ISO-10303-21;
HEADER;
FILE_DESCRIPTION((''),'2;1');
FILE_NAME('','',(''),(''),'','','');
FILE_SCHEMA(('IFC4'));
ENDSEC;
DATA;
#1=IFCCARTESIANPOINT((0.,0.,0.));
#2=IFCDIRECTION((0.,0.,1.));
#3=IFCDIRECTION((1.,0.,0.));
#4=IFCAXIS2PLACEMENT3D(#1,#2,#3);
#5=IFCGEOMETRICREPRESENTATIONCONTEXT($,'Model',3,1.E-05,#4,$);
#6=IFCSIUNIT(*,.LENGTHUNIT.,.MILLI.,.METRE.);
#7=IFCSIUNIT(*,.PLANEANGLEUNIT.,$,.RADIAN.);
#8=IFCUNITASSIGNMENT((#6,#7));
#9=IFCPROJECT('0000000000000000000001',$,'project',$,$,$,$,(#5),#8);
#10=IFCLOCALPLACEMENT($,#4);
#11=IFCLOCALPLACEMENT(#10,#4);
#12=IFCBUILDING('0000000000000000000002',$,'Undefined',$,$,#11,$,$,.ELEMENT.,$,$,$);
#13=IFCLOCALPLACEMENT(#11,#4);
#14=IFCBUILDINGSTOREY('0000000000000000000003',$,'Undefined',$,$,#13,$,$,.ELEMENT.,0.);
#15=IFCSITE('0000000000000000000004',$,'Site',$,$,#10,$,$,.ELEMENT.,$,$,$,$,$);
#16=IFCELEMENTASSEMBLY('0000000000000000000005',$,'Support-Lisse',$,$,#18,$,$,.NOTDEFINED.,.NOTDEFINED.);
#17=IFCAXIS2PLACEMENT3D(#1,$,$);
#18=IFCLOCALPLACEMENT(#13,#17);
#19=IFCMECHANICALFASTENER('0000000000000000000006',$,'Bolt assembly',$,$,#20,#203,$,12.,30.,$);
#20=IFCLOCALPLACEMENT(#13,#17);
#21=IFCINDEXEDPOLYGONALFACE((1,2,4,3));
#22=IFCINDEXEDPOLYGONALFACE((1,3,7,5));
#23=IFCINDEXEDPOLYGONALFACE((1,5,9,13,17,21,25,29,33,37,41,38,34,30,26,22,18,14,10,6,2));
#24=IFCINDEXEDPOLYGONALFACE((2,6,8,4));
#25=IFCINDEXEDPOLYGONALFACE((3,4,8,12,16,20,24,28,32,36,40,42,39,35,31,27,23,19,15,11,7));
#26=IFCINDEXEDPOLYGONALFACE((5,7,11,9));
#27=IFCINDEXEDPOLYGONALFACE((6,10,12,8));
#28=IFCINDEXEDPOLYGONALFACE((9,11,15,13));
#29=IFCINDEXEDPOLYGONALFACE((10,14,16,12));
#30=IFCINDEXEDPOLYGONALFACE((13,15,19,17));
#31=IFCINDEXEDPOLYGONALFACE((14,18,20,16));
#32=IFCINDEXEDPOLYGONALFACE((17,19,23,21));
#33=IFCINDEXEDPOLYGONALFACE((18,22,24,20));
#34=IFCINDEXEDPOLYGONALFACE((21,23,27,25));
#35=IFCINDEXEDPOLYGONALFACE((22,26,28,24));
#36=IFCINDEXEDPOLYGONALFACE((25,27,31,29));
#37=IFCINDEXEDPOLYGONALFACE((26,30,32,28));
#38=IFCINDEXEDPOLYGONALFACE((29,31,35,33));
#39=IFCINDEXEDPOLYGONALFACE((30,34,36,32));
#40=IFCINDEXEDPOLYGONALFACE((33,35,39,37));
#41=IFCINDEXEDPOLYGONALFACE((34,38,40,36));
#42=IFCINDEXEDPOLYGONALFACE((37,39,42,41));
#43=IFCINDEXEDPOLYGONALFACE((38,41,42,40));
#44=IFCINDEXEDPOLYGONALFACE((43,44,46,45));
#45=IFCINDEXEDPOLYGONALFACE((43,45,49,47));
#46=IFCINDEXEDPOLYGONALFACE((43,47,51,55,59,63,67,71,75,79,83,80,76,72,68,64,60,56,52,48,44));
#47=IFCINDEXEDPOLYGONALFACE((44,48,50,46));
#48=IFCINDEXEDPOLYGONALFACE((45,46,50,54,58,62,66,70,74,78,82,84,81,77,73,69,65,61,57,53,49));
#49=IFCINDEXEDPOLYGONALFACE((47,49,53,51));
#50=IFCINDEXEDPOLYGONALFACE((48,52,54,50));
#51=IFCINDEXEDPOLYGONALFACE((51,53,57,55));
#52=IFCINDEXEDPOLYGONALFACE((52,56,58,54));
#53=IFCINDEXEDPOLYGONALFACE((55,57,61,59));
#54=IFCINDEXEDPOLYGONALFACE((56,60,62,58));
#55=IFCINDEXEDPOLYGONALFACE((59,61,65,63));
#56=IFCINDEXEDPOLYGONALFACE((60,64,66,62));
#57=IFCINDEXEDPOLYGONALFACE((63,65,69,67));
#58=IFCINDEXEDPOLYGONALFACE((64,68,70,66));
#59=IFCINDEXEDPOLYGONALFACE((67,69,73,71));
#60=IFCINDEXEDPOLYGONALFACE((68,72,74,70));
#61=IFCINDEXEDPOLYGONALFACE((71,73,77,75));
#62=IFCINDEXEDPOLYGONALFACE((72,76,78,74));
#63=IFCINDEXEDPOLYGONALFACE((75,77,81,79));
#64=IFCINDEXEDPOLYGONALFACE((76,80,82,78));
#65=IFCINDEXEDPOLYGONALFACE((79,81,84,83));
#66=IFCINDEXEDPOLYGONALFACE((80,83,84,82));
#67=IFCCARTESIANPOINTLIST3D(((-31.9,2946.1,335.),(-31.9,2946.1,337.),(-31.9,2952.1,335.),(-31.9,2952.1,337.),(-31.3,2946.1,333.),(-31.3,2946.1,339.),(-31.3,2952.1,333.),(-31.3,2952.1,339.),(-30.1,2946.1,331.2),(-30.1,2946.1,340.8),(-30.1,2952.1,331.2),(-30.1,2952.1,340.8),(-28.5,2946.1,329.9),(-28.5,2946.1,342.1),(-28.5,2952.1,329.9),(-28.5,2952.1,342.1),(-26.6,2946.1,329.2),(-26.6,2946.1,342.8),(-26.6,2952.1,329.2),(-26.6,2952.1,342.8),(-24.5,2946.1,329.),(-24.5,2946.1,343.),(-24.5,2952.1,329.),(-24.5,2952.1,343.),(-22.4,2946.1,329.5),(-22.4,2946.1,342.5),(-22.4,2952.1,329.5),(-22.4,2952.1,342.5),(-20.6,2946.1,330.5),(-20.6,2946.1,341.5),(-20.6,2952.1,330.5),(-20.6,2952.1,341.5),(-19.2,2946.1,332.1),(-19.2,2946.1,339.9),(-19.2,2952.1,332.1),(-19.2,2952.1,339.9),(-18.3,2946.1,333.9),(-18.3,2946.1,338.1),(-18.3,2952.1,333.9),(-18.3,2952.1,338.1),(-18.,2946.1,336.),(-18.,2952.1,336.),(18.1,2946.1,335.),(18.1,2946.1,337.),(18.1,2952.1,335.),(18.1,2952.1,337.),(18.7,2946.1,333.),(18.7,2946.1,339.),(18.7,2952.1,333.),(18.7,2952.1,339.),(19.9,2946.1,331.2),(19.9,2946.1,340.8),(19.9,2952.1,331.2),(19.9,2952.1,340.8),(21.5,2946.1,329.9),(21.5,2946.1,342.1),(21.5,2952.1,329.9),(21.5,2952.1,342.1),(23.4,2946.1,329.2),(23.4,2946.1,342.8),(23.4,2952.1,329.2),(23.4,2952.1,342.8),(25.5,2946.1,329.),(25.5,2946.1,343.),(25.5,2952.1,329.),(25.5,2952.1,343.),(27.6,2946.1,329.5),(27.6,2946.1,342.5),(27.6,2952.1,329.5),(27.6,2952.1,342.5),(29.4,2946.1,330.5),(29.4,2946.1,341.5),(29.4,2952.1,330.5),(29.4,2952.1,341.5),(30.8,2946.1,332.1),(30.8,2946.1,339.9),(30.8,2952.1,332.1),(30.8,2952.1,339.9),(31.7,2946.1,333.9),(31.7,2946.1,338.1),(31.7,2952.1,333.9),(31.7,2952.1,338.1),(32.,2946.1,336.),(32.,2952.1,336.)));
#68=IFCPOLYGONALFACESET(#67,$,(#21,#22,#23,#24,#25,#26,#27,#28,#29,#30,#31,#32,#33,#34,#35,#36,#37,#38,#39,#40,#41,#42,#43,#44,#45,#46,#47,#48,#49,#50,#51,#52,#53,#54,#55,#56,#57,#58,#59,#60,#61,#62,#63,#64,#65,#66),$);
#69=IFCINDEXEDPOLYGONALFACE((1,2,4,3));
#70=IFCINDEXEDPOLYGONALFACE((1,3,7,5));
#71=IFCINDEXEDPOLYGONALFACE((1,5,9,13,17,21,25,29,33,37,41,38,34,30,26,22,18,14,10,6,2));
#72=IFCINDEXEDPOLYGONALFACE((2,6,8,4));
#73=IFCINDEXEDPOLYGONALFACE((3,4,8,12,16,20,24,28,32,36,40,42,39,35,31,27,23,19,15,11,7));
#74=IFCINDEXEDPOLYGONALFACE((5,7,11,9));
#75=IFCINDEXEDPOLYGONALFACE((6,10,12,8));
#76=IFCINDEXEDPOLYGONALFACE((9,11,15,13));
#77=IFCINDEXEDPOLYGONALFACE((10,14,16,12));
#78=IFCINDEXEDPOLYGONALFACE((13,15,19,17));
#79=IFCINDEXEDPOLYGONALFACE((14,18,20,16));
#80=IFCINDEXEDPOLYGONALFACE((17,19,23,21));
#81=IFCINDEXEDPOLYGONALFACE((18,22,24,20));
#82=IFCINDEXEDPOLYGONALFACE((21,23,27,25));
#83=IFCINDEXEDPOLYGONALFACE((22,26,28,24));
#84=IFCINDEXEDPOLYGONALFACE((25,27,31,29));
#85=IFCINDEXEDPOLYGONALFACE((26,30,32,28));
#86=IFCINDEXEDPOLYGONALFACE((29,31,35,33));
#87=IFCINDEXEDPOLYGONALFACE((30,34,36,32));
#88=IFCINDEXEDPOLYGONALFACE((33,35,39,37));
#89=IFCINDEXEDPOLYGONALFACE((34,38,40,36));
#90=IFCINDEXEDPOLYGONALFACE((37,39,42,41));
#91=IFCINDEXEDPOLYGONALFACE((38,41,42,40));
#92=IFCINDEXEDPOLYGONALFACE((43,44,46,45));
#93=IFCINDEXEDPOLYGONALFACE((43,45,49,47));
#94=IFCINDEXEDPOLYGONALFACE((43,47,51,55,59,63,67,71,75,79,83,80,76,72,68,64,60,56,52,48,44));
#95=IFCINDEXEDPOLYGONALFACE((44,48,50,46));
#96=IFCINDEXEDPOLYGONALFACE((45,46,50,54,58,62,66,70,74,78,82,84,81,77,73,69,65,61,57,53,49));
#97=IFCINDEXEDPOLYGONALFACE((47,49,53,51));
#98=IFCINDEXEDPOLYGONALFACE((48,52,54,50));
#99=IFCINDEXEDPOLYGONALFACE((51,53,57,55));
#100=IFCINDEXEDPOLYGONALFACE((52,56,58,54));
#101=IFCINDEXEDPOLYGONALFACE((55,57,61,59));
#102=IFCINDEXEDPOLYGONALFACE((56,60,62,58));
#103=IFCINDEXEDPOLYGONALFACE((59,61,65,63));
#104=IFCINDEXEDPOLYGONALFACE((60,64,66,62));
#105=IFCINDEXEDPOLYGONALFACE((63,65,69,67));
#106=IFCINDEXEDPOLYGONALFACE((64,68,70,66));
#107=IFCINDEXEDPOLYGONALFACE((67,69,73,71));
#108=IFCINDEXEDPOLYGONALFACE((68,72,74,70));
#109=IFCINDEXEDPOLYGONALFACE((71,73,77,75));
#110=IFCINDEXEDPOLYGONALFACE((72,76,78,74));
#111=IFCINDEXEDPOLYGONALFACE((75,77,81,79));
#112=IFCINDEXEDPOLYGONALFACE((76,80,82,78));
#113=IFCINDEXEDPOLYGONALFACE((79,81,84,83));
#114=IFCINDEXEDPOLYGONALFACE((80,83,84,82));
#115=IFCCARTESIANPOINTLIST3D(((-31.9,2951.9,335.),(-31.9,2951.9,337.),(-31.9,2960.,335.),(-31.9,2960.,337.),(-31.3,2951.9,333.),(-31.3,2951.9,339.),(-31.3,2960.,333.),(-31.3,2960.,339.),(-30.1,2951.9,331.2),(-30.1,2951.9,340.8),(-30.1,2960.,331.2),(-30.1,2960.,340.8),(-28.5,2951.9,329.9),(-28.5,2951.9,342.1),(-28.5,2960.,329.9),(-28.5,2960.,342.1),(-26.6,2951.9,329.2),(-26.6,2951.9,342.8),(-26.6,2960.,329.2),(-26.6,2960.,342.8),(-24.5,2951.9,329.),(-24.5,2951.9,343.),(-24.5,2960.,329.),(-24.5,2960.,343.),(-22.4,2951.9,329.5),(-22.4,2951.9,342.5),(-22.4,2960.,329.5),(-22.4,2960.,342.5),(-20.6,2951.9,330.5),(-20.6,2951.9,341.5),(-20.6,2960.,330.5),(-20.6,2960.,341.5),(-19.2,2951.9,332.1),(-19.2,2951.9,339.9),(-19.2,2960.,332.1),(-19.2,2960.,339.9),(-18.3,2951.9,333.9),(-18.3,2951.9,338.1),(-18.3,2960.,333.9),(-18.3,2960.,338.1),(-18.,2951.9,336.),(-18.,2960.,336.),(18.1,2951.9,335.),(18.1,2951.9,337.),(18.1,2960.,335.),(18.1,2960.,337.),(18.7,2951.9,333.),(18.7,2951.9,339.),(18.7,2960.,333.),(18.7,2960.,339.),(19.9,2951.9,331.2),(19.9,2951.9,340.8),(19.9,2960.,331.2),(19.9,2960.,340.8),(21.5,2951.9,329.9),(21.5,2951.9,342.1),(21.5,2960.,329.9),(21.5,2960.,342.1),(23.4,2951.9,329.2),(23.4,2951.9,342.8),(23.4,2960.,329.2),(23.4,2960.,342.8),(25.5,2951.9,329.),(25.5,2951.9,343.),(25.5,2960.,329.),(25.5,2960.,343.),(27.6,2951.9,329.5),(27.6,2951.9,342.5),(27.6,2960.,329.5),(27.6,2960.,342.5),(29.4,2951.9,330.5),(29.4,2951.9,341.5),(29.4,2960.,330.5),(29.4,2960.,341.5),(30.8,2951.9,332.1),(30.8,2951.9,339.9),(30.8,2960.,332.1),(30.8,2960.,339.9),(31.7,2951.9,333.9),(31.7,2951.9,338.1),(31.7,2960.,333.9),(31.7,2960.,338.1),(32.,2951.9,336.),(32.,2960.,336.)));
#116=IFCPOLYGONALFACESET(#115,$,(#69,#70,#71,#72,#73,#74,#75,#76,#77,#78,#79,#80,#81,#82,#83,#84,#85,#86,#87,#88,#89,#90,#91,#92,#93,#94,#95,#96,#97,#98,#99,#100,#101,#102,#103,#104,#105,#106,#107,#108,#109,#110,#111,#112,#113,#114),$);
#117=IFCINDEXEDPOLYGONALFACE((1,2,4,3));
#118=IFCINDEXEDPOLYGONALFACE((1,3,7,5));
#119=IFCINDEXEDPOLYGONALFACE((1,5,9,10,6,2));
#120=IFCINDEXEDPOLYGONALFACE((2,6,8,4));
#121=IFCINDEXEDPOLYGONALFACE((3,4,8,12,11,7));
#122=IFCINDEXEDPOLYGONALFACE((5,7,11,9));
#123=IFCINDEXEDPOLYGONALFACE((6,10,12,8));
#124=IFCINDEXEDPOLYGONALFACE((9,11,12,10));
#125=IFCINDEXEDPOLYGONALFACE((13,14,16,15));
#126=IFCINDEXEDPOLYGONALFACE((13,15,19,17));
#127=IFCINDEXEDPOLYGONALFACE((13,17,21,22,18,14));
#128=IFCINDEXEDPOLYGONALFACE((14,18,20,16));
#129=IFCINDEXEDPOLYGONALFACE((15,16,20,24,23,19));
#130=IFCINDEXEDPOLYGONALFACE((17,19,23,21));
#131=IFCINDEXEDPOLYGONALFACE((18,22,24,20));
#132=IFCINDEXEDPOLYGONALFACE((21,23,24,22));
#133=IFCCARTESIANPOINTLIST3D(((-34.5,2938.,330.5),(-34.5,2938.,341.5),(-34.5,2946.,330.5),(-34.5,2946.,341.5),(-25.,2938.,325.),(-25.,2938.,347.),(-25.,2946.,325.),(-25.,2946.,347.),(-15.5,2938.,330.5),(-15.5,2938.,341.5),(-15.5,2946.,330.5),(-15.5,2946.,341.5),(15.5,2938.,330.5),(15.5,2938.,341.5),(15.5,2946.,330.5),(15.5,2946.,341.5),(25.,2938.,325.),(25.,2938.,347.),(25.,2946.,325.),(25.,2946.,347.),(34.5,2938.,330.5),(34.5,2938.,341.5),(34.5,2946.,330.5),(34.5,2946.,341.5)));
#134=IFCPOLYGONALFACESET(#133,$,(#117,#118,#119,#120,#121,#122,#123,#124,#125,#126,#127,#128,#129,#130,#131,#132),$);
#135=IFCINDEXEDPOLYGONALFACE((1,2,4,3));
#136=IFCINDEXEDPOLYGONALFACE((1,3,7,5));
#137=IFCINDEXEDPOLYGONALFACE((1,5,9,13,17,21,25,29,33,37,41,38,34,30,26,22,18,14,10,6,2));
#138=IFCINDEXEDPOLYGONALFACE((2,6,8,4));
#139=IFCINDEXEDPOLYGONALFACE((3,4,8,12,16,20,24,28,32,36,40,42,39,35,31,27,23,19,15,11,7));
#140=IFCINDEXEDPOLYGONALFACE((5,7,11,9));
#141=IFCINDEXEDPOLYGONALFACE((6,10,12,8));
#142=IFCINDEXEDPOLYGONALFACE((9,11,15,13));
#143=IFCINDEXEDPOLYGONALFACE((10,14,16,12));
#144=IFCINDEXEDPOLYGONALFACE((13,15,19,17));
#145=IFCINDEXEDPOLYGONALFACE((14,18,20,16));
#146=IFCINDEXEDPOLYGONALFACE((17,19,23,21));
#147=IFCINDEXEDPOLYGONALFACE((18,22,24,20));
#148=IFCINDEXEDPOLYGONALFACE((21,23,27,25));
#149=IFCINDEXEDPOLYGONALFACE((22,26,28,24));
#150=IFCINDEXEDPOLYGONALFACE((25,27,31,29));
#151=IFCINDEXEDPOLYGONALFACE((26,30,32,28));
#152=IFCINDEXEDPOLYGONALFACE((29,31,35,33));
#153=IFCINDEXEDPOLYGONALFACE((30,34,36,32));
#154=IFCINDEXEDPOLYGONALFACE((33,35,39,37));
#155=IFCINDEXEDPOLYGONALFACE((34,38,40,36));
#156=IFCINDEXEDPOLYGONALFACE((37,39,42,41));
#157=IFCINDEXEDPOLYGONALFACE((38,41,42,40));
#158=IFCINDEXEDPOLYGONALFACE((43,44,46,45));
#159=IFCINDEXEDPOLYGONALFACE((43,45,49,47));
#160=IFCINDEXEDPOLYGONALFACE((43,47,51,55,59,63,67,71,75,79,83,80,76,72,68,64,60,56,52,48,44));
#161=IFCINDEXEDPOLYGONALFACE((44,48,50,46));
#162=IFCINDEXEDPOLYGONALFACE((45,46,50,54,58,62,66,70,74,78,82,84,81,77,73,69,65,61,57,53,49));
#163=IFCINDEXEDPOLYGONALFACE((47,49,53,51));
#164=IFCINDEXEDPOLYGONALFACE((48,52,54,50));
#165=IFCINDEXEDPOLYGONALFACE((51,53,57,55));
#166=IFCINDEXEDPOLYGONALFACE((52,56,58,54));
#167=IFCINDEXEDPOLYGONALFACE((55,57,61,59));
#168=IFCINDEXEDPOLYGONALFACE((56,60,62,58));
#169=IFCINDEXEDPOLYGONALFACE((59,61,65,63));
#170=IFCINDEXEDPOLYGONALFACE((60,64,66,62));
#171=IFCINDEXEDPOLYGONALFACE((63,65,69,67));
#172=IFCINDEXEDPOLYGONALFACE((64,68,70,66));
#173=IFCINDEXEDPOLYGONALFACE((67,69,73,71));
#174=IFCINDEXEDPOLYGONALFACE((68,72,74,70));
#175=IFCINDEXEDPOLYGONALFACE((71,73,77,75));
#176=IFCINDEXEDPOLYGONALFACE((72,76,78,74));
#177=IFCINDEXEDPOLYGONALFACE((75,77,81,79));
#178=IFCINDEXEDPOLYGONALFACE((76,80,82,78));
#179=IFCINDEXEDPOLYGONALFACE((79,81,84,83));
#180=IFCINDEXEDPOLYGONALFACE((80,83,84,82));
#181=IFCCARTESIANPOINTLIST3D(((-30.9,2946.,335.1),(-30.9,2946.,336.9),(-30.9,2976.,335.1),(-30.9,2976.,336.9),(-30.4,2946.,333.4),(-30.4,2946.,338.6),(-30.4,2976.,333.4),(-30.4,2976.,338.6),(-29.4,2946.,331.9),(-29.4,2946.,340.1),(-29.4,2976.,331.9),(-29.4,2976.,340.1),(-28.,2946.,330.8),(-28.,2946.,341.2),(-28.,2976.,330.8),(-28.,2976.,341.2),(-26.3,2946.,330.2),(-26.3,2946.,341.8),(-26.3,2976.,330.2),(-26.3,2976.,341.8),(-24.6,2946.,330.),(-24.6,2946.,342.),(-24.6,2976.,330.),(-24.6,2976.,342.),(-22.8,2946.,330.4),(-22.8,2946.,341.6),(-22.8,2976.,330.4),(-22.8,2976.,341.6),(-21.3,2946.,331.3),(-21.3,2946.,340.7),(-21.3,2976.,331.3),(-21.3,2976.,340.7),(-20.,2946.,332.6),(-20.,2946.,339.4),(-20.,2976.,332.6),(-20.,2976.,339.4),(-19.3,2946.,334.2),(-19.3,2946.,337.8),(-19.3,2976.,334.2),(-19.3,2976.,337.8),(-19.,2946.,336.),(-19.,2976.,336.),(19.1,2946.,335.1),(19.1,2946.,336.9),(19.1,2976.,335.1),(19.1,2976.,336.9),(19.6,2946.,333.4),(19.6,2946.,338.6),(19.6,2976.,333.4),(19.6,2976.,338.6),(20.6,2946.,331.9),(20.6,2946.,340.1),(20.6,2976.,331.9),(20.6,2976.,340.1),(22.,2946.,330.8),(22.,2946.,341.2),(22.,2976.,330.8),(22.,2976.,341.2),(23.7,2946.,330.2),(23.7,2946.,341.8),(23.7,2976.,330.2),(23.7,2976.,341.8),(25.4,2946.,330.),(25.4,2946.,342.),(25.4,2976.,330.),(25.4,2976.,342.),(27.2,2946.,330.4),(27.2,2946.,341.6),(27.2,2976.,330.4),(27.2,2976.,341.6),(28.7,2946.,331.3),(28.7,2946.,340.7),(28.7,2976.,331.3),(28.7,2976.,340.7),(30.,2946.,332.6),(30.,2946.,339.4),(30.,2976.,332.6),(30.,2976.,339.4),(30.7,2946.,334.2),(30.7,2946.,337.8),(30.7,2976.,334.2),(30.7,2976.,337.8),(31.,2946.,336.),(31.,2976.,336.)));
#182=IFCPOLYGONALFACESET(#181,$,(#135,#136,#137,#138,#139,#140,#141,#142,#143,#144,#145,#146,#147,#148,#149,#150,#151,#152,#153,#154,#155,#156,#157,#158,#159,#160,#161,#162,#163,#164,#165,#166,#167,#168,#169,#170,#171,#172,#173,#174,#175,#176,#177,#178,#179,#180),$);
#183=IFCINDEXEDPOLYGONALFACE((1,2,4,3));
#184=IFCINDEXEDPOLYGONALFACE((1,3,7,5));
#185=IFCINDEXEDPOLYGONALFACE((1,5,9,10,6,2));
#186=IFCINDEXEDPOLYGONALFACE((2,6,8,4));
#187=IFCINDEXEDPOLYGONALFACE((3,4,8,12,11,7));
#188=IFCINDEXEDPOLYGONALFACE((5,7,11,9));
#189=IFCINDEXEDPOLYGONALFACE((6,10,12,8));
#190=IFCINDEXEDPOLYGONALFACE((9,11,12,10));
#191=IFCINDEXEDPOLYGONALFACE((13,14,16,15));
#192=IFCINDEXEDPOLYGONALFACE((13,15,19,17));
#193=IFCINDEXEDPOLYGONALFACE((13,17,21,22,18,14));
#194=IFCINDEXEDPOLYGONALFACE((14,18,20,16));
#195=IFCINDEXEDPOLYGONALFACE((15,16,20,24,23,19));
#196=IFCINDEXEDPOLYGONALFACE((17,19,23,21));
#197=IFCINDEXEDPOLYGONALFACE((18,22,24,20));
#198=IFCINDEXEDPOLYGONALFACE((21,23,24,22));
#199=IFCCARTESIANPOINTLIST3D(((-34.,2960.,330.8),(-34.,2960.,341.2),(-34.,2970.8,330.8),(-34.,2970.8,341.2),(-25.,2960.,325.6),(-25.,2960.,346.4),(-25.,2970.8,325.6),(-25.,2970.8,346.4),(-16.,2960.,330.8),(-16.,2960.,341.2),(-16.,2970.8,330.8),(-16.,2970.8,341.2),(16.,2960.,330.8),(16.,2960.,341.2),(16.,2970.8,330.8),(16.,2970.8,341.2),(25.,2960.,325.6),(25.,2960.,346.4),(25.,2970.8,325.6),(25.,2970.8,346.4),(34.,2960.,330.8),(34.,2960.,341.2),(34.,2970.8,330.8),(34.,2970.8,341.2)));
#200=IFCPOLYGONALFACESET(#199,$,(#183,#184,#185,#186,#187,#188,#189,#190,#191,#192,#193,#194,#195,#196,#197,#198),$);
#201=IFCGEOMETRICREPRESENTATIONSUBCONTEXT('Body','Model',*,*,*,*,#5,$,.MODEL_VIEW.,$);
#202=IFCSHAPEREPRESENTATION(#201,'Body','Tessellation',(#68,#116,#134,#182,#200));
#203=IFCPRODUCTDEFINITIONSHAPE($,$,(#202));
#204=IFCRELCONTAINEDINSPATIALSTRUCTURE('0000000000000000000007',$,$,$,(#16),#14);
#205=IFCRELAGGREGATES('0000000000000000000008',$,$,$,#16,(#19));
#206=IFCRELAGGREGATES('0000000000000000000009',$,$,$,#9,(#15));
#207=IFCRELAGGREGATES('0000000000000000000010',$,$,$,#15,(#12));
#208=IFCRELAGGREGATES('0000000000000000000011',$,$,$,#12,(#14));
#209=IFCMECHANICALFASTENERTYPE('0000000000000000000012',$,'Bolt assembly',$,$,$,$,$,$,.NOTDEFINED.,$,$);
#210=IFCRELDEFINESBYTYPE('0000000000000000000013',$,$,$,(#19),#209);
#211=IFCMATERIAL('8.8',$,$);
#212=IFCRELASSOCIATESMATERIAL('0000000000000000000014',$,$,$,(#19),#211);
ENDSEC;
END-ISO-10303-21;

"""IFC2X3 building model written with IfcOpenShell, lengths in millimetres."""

from ifc_helpers import new_model, si_unit, frame, origin_with_axes, origin_2d_with_axis, place, context, subcontext, project, spatial, polyline, circle, outline, extrude, source, transform, mapped, material, type_object, element, aggregate, save


model = new_model("IFC2X3")

# Units and contexts
model_context = context("Model", 3, precision=1e-05, world=origin_with_axes())
body_context = subcontext(model_context, "Body", "Model", "MODEL_VIEW")
ifc_project = project(units=[si_unit("LENGTHUNIT", "METRE", prefix="MILLI"), si_unit("PLANEANGLEUNIT", "RADIAN")], contexts=[model_context])

# Site, building, storey
site_placement = place(None, origin_with_axes())
site = spatial("IfcSite", under=ifc_project, at=site_placement, Name="Site", CompositionType="ELEMENT")
building_placement = place(site_placement, origin_with_axes())
building = spatial("IfcBuilding", under=site, at=building_placement, Name="Undefined", CompositionType="ELEMENT")
storey_placement = place(building_placement, origin_with_axes())
storey = spatial("IfcBuildingStorey", under=building, at=storey_placement, Name="Undefined", CompositionType="ELEMENT", Elevation=0.0)

# Shared definitions
mechanical_fastener_type = type_object("IfcMechanicalFastenerType", Name="Bolt assembly")
ifc_material_1 = material(Name="8.8")

# Element assembly
assembly_1_placement = place(storey_placement, origin_with_axes())
assembly_1 = element("IfcElementAssembly", 1, at=assembly_1_placement, inside=storey, Name="Support-Lisse", AssemblyPlace="NOTDEFINED", PredefinedType="NOTDEFINED")

# Mechanical fastener
shared_shape_1 = source(origin_with_axes(), body_context, "Body", "SweptSolid", [
    extrude(circle(Radius=7.0, at=origin_2d_with_axis()), frame((0.0, -5.9, 0.0), z_axis=(0.0, 1.0, 0.0), x_axis=(1.0, 0.0, 0.0)), (0.0, 0.0, 1.0), 6.0),
    extrude(circle(Radius=7.0, at=origin_2d_with_axis()), frame((0.0, -0.1, 0.0), z_axis=(0.0, 1.0, 0.0), x_axis=(1.0, 0.0, 0.0)), (0.0, 0.0, 1.0), 8.1),
    extrude(outline(polyline([(9.5, -5.5), (9.5, 5.5), (0.0, 11.0), (-9.5, 5.5), (-9.5, -5.5), (0.0, -11.0), (9.5, -5.5)])), frame((0.0, -14.0, 0.0), z_axis=(0.0, 1.0, 0.0), x_axis=(1.0, 0.0, 0.0)), (0.0, 0.0, 1.0), 8.0),
    extrude(circle(Radius=6.0, at=origin_2d_with_axis()), frame((0.0, -6.0, 0.0), z_axis=(0.0, 1.0, 0.0), x_axis=(1.0, 0.0, 0.0)), (0.0, 0.0, 1.0), 30.0),
    extrude(outline(polyline([(9.0, -5.2), (9.0, 5.2), (0.0, 10.4), (-9.0, 5.2), (-9.0, -5.2), (0.0, -10.4), (9.0, -5.2)])), frame((0.0, 8.0, 0.0), z_axis=(0.0, 1.0, 0.0), x_axis=(1.0, 0.0, 0.0)), (0.0, 0.0, 1.0), 10.8),
])
mechanical_fastener_1_placement = place(assembly_1_placement, frame((-25.0, 2952.0, 336.0), z_axis=(0.0, 0.0, 1.0), x_axis=(1.0, 0.0, 0.0)))
mechanical_fastener_1 = element("IfcMechanicalFastener", 2, at=mechanical_fastener_1_placement, type_object=mechanical_fastener_type, material=ifc_material_1, Name="Bolt assembly", NominalDiameter=12.0, NominalLength=30.0, context=body_context, shape_type="MappedRepresentation", body=[
    mapped(shared_shape_1, transform((0.0, 0.0, 0.0))),
    mapped(shared_shape_1, transform((50.0, 0.0, 0.0))),
])
aggregate(assembly_1, [mechanical_fastener_1])

save(model, "model.ifc")
